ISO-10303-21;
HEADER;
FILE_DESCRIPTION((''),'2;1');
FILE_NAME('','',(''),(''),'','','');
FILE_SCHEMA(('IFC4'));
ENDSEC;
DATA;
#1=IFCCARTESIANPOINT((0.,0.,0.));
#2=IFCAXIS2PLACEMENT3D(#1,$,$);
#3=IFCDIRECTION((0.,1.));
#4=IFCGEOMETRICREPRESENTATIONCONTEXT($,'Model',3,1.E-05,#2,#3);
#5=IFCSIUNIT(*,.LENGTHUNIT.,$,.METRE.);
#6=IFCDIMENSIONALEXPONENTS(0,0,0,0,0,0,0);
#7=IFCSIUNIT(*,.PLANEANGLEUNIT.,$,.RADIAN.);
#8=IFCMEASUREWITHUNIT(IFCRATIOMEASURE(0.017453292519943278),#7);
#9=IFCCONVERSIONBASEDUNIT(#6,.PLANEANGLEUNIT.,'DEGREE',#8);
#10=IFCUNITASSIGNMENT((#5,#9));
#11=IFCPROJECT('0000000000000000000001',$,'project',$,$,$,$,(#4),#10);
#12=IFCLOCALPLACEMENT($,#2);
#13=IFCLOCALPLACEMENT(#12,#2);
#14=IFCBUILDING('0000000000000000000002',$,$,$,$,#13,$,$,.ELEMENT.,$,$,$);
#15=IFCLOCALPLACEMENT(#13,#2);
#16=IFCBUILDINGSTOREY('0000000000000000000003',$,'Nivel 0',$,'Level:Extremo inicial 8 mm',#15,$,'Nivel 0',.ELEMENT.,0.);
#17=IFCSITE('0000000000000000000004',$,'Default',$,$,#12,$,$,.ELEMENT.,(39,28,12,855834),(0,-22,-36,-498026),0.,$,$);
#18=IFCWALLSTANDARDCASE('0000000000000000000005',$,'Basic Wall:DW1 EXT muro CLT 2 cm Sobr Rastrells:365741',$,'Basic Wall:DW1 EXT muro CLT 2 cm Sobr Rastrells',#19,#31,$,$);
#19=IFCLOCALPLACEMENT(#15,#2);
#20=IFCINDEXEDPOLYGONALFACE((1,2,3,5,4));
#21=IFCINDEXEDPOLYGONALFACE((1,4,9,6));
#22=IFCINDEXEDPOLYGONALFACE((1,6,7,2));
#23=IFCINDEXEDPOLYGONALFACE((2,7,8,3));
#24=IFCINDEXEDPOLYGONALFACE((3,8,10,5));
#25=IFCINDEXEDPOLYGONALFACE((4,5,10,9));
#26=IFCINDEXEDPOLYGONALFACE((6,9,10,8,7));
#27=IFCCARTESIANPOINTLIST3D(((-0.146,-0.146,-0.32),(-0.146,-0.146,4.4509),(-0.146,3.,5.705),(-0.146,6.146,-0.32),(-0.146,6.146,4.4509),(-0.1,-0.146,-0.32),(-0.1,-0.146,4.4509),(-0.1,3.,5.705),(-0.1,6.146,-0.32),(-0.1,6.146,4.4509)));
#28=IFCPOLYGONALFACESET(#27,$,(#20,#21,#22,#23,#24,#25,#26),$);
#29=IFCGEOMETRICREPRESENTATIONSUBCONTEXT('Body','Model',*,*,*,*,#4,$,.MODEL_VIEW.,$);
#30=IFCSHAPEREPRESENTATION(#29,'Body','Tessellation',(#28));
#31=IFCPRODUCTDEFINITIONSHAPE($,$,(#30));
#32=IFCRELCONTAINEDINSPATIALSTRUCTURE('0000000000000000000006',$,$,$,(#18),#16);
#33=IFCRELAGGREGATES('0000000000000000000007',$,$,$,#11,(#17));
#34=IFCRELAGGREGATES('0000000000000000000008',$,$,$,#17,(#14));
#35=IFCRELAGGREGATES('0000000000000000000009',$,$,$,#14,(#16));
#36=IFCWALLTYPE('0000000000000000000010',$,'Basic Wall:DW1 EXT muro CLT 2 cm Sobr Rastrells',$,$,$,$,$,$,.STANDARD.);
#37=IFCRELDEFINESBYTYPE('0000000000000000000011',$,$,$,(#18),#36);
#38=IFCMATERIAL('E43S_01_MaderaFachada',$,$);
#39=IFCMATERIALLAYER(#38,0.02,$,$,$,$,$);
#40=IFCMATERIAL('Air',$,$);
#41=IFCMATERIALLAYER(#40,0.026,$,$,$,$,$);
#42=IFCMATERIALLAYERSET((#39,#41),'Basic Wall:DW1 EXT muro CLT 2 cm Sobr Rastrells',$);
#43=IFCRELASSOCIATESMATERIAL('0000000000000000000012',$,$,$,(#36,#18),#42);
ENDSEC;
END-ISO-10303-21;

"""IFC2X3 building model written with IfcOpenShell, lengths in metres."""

from ifc_helpers import new_model, entity, si_unit, converted_unit, direction, frame, frame_2d, origin, place, context, subcontext, project, spatial, polyline, rectangle, extrude, clip, bounded_halfspace, material, layer, layer_set, layer_usage, type_object, element, save


model = new_model("IFC2X3")

# Units and contexts
model_context = context("Model", 3, precision=1e-05, world=origin(), true_north=direction((0.0, 1.0)))
body_context = subcontext(model_context, "Body", "Model", "MODEL_VIEW")
ifc_project = project(units=[si_unit("LENGTHUNIT", "METRE"), converted_unit("PLANEANGLEUNIT", "DEGREE", entity("IfcRatioMeasure", 0.017453292519943278), si_unit("PLANEANGLEUNIT", "RADIAN"), dimensions=[0, 0, 0, 0, 0, 0, 0])], contexts=[model_context])

# Site, building, storey
site_placement = place(None, origin())
site = spatial("IfcSite", under=ifc_project, at=site_placement, Name="Default", CompositionType="ELEMENT", RefLatitude=(39, 28, 12, 855834), RefLongitude=(0, -22, -36, -498026), RefElevation=0.0)
building_placement = place(site_placement, origin())
building = spatial("IfcBuilding", under=site, at=building_placement, CompositionType="ELEMENT")
storey_placement = place(building_placement, origin())
storey = spatial("IfcBuildingStorey", under=building, at=storey_placement, Name="Nivel 0", ObjectType="Level:Extremo inicial 8 mm", LongName="Nivel 0", CompositionType="ELEMENT", Elevation=0.0)

# Wall
ifc_material_1 = material(Name="E43S_01_MaderaFachada")
ifc_layer_1 = layer(ifc_material_1, 0.02)
ifc_material_2 = material(Name="Air")
ifc_layer_2 = layer(ifc_material_2, 0.026)
ifc_layer_set_1 = layer_set([ifc_layer_1, ifc_layer_2], Name="Basic Wall:DW1 EXT muro CLT 2 cm Sobr Rastrells")
ifc_layer_usage_1 = layer_usage(ifc_layer_set_1, "AXIS2", "NEGATIVE", 0.023)
wall_type_1 = type_object("IfcWallType", Name="Basic Wall:DW1 EXT muro CLT 2 cm Sobr Rastrells", PredefinedType="STANDARD", material=ifc_layer_set_1)
wall_1_placement = place(storey_placement, frame((-0.123, -0.146, -0.32), z_axis=(0.0, 0.0, 1.0), x_axis=(0.0, 1.0, 0.0)))
element("IfcWallStandardCase", 1, at=wall_1_placement, inside=storey, type_object=wall_type_1, material=ifc_layer_usage_1, Name="Basic Wall:DW1 EXT muro CLT 2 cm Sobr Rastrells:365741", ObjectType="Basic Wall:DW1 EXT muro CLT 2 cm Sobr Rastrells", context=body_context, shape_type="Clipping", body=[
    clip(clip(extrude(rectangle(XDim=6.292, YDim=0.046, at=frame_2d((3.146, 0.0), x_axis=(-1.0, 0.0))), origin(), (0.0, 0.0, 1.0), 6.025), bounded_halfspace(frame((0.0, -0.023, 4.7709), z_axis=(-0.370288, 0.0, 0.928917), x_axis=(0.0, -1.0, 0.0)), False, frame((0.0, -0.023, 4.7709)), polyline([(0.0, 0.0), (0.046, 0.0), (3.146, 0.0), (3.146, 0.046), (0.0, 0.046), (0.0, 0.0)]))), bounded_halfspace(frame((3.146, -0.023, 6.025), z_axis=(0.370288, 0.0, 0.928917), x_axis=(0.0, 1.0, 0.0)), False, frame((3.146, -0.023, 6.025)), polyline([(0.0, 0.0), (3.1, 0.0), (3.146, 0.0), (3.146, 0.046), (0.0, 0.046), (0.0, 0.0)]))),
])

save(model, "model.ifc")
